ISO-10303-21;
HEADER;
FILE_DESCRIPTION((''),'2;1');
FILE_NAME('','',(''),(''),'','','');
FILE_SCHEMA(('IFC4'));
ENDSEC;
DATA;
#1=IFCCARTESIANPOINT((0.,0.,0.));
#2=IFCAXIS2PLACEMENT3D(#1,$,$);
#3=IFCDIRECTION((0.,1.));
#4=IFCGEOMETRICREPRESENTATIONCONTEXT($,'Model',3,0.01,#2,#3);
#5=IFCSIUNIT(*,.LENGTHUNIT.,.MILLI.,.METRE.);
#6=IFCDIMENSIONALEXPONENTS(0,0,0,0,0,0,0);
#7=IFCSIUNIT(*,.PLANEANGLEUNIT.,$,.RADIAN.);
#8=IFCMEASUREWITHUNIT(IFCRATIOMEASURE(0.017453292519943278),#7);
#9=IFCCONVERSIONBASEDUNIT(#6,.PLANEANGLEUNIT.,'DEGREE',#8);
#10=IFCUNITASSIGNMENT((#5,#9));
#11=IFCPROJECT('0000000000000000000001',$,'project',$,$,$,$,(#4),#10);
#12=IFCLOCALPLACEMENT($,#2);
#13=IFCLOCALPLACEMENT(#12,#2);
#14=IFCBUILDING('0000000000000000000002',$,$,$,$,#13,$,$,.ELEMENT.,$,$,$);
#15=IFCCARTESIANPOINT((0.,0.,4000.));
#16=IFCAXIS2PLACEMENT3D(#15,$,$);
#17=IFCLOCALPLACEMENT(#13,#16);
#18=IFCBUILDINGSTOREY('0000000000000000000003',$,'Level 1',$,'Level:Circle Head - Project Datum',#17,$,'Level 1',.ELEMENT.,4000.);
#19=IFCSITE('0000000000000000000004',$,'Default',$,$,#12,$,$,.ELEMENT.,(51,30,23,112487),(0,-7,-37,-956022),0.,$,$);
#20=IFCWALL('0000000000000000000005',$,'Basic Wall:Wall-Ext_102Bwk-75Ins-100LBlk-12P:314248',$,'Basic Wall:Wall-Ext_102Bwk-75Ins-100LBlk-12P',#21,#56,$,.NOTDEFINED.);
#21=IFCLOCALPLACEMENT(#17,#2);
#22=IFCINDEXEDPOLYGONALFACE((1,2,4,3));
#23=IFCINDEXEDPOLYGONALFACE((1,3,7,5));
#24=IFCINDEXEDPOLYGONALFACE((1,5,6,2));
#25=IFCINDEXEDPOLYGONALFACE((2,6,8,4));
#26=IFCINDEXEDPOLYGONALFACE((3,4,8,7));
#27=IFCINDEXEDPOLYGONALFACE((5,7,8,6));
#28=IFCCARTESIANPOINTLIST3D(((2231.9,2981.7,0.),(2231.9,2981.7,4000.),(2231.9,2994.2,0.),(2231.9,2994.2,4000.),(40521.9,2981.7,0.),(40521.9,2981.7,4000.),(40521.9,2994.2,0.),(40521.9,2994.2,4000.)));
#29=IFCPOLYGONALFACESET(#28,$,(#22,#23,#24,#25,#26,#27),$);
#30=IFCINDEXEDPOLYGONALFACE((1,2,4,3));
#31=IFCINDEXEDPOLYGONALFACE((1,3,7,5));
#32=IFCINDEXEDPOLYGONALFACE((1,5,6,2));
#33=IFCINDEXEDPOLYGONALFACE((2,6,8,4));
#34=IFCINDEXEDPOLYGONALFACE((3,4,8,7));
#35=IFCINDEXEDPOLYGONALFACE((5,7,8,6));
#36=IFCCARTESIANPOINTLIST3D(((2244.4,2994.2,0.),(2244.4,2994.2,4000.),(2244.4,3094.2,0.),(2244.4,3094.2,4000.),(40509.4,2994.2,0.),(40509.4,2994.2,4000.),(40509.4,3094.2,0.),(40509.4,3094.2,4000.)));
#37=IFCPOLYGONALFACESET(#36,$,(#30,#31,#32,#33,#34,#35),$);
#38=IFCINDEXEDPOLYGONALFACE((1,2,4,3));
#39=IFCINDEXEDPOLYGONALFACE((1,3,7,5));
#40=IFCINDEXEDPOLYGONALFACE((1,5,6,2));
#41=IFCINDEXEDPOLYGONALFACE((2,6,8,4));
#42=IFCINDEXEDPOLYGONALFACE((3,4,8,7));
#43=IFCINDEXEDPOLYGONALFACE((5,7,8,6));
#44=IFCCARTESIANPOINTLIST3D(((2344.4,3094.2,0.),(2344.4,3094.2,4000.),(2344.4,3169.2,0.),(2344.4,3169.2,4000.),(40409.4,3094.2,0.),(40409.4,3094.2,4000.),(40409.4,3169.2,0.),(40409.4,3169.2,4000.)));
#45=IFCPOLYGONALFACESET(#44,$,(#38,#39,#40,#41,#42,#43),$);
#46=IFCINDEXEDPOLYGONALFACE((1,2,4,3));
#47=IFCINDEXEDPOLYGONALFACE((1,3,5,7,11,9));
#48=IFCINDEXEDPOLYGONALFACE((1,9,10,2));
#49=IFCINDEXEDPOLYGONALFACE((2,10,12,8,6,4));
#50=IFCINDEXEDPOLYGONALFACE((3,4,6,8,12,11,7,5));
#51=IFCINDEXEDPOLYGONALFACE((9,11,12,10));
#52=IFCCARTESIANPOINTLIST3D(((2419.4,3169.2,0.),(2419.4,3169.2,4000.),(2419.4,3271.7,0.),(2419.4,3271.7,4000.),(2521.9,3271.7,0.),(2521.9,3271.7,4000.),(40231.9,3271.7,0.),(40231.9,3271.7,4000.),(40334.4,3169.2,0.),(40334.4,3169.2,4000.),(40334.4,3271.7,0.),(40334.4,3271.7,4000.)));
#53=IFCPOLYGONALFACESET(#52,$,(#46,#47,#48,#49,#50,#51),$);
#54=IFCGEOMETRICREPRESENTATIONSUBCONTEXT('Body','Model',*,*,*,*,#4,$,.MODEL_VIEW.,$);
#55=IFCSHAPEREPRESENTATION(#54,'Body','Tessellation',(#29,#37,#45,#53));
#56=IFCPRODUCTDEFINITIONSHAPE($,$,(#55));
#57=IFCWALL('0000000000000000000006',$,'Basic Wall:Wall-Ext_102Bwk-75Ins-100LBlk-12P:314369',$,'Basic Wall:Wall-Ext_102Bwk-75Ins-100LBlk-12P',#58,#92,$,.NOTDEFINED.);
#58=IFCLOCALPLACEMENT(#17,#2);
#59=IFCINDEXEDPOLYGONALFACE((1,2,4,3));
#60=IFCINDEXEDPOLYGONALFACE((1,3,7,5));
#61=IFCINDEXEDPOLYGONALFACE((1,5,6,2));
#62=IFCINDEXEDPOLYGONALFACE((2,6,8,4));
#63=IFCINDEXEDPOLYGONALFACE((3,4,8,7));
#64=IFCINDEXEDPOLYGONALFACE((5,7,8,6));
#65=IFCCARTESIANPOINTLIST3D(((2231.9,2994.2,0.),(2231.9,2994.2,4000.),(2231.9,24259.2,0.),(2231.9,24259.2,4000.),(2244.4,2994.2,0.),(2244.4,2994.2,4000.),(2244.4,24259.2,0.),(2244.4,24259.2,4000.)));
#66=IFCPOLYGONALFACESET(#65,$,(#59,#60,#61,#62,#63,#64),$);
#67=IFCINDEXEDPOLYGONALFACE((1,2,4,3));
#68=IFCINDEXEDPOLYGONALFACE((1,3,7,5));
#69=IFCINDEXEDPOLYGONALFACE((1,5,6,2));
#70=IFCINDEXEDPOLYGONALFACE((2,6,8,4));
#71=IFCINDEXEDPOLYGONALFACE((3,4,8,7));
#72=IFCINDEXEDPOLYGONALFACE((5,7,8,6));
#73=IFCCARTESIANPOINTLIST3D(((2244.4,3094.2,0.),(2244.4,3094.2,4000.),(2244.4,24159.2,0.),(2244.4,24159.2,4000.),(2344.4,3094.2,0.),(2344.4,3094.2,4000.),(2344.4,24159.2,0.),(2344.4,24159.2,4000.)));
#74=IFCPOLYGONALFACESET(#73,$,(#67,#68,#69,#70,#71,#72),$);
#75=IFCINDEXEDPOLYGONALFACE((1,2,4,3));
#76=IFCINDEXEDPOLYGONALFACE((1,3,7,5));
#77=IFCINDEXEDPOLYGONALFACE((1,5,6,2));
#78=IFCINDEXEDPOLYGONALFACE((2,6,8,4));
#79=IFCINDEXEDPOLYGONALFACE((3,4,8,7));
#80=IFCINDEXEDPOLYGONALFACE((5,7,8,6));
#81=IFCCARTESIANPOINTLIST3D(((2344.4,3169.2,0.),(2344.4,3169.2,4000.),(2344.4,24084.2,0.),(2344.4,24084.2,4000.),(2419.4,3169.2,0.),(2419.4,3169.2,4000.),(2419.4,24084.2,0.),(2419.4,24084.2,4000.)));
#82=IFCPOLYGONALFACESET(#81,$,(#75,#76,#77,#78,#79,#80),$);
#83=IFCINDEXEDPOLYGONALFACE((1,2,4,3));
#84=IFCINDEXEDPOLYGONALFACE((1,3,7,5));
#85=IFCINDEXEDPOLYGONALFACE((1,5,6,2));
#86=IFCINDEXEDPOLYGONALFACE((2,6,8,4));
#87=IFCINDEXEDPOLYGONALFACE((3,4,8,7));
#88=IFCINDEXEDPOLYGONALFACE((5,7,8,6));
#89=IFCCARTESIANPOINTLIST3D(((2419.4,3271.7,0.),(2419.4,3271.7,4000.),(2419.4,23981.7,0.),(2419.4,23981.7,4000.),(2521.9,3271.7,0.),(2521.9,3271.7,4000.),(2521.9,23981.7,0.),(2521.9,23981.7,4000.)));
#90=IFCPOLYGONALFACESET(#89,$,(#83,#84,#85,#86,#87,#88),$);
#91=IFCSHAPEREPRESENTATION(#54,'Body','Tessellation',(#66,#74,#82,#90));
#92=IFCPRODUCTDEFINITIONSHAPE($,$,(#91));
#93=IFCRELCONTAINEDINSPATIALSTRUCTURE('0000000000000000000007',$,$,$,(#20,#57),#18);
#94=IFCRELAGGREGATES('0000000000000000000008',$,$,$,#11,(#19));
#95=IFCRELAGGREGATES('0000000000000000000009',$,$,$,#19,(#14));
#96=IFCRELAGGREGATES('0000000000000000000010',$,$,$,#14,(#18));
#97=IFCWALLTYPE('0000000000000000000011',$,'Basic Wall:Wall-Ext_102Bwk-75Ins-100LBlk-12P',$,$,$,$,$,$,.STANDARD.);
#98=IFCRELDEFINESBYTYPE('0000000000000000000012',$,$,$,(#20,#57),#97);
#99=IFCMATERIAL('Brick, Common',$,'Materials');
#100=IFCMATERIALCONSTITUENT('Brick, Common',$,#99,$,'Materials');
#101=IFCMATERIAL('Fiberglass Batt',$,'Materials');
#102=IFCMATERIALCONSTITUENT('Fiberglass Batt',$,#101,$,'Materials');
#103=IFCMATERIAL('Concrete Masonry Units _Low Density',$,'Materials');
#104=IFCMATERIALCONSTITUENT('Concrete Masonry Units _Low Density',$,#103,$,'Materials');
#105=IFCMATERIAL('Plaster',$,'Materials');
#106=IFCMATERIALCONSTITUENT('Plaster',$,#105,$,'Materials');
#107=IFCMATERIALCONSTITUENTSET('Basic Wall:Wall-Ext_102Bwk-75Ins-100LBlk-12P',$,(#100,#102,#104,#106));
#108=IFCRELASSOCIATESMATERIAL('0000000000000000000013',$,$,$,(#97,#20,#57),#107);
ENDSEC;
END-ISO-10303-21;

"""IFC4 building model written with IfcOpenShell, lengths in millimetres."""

from ifc_helpers import new_model, entity, si_unit, converted_unit, direction, frame, origin, place, context, subcontext, project, spatial, indexed_curve, outline, extrude, material, constituent, constituent_set, type_object, element, save


model = new_model("IFC4")

# Units and contexts
model_context = context("Model", 3, precision=0.01, world=origin(), true_north=direction((0.0, 1.0)))
body_context = subcontext(model_context, "Body", "Model", "MODEL_VIEW")
ifc_project = project(units=[si_unit("LENGTHUNIT", "METRE", prefix="MILLI"), converted_unit("PLANEANGLEUNIT", "DEGREE", entity("IfcRatioMeasure", 0.017453292519943278), si_unit("PLANEANGLEUNIT", "RADIAN"), dimensions=[0, 0, 0, 0, 0, 0, 0])], contexts=[model_context])

# Site, building, storey
site_placement = place(None, origin())
site = spatial("IfcSite", under=ifc_project, at=site_placement, Name="Default", CompositionType="ELEMENT", RefLatitude=(51, 30, 23, 112487), RefLongitude=(0, -7, -37, -956022), RefElevation=0.0)
building_placement = place(site_placement, origin())
building = spatial("IfcBuilding", under=site, at=building_placement, CompositionType="ELEMENT")
storey_placement = place(building_placement, frame((0.0, 0.0, 4000.0)))
storey = spatial("IfcBuildingStorey", under=building, at=storey_placement, Name="Level 1", ObjectType="Level:Circle Head - Project Datum", LongName="Level 1", CompositionType="ELEMENT", Elevation=4000.0)

# Walls
ifc_material_1 = material(Name="Brick, Common", Category="Materials")
ifc_constituent_1 = constituent(ifc_material_1, Name="Brick, Common", Category="Materials")
ifc_material_2 = material(Name="Fiberglass Batt", Category="Materials")
ifc_constituent_2 = constituent(ifc_material_2, Name="Fiberglass Batt", Category="Materials")
ifc_material_3 = material(Name="Concrete Masonry Units _Low Density", Category="Materials")
ifc_constituent_3 = constituent(ifc_material_3, Name="Concrete Masonry Units _Low Density", Category="Materials")
ifc_material_4 = material(Name="Plaster", Category="Materials")
ifc_constituent_4 = constituent(ifc_material_4, Name="Plaster", Category="Materials")
ifc_constituent_set_1 = constituent_set(constituents=[ifc_constituent_1, ifc_constituent_2, ifc_constituent_3, ifc_constituent_4], Name="Basic Wall:Wall-Ext_102Bwk-75Ins-100LBlk-12P")
wall_type = type_object("IfcWallType", Name="Basic Wall:Wall-Ext_102Bwk-75Ins-100LBlk-12P", PredefinedType="STANDARD", material=ifc_constituent_set_1)
wall_1_placement = place(storey_placement, frame((2231.9, 3126.7, 0.0)))
element("IfcWall", 1, at=wall_1_placement, inside=storey, type_object=wall_type, material=ifc_constituent_set_1, Name="Basic Wall:Wall-Ext_102Bwk-75Ins-100LBlk-12P:314248", ObjectType="Basic Wall:Wall-Ext_102Bwk-75Ins-100LBlk-12P", PredefinedType="NOTDEFINED", context=body_context, shape_type="SweptSolid", body=[
    extrude(outline(indexed_curve([(-6.3, -19145.0), (6.2, -19145.0), (6.3, 19145.0), (-6.2, 19145.0), (-6.3, -19145.0)], self_intersect=False)), frame((19145.0, -138.7, 0.0), z_axis=(0.0, 0.0, 1.0), x_axis=(0.0, 1.0, 0.0)), (0.0, 0.0, 1.0), 4000.0),
    extrude(outline(indexed_curve([(-19132.5, -50.0), (19132.5, -50.0), (19132.5, 50.0), (-19132.5, 50.0), (-19132.5, -50.0)], self_intersect=False)), frame((19145.0, -82.5, 0.0)), (0.0, 0.0, 1.0), 4000.0),
    extrude(outline(indexed_curve([(-19032.5, -37.5), (19032.5, -37.5), (19032.5, 37.5), (-19032.5, 37.5), (-19032.5, -37.5)], self_intersect=False)), frame((19145.0, 5.0, 0.0)), (0.0, 0.0, 1.0), 4000.0),
    extrude(outline(indexed_curve([(-18855.0, -34.2), (18855.0, -34.2), (18957.5, -34.2), (18957.5, 68.3), (-18957.5, 68.3), (-18957.5, -34.2), (-18855.0, -34.2)], self_intersect=False)), frame((19145.0, 110.8, 0.0), z_axis=(0.0, 0.0, 1.0), x_axis=(-1.0, 0.0, 0.0)), (0.0, 0.0, 1.0), 4000.0),
])
wall_2_placement = place(storey_placement, frame((2376.9, 23981.7, 0.0), z_axis=(0.0, 0.0, 1.0), x_axis=(0.0, -1.0, 0.0)))
element("IfcWall", 2, at=wall_2_placement, inside=storey, type_object=wall_type, material=ifc_constituent_set_1, Name="Basic Wall:Wall-Ext_102Bwk-75Ins-100LBlk-12P:314369", ObjectType="Basic Wall:Wall-Ext_102Bwk-75Ins-100LBlk-12P", PredefinedType="NOTDEFINED", context=body_context, shape_type="SweptSolid", body=[
    extrude(outline(indexed_curve([(-6.3, -10632.5), (6.2, -10632.5), (6.3, 10632.5), (-6.2, 10632.5), (-6.3, -10632.5)], self_intersect=False)), frame((10355.0, -138.7, 0.0), z_axis=(0.0, 0.0, 1.0), x_axis=(0.0, 1.0, 0.0)), (0.0, 0.0, 1.0), 4000.0),
    extrude(outline(indexed_curve([(-10532.5, -50.0), (10532.5, -50.0), (10532.5, 50.0), (-10532.5, 50.0), (-10532.5, -50.0)], self_intersect=False)), frame((10355.0, -82.5, 0.0)), (0.0, 0.0, 1.0), 4000.0),
    extrude(outline(indexed_curve([(-10457.5, -37.5), (10457.5, -37.5), (10457.5, 37.5), (-10457.5, 37.5), (-10457.5, -37.5)], self_intersect=False)), frame((10355.0, 5.0, 0.0)), (0.0, 0.0, 1.0), 4000.0),
    extrude(outline(indexed_curve([(-51.3, -10355.0), (51.2, -10355.0), (51.3, 10355.0), (-51.2, 10355.0), (-51.3, -10355.0)], self_intersect=False)), frame((10355.0, 93.8, 0.0), z_axis=(0.0, 0.0, 1.0), x_axis=(0.0, -1.0, 0.0)), (0.0, 0.0, 1.0), 4000.0),
])

save(model, "model.ifc")
